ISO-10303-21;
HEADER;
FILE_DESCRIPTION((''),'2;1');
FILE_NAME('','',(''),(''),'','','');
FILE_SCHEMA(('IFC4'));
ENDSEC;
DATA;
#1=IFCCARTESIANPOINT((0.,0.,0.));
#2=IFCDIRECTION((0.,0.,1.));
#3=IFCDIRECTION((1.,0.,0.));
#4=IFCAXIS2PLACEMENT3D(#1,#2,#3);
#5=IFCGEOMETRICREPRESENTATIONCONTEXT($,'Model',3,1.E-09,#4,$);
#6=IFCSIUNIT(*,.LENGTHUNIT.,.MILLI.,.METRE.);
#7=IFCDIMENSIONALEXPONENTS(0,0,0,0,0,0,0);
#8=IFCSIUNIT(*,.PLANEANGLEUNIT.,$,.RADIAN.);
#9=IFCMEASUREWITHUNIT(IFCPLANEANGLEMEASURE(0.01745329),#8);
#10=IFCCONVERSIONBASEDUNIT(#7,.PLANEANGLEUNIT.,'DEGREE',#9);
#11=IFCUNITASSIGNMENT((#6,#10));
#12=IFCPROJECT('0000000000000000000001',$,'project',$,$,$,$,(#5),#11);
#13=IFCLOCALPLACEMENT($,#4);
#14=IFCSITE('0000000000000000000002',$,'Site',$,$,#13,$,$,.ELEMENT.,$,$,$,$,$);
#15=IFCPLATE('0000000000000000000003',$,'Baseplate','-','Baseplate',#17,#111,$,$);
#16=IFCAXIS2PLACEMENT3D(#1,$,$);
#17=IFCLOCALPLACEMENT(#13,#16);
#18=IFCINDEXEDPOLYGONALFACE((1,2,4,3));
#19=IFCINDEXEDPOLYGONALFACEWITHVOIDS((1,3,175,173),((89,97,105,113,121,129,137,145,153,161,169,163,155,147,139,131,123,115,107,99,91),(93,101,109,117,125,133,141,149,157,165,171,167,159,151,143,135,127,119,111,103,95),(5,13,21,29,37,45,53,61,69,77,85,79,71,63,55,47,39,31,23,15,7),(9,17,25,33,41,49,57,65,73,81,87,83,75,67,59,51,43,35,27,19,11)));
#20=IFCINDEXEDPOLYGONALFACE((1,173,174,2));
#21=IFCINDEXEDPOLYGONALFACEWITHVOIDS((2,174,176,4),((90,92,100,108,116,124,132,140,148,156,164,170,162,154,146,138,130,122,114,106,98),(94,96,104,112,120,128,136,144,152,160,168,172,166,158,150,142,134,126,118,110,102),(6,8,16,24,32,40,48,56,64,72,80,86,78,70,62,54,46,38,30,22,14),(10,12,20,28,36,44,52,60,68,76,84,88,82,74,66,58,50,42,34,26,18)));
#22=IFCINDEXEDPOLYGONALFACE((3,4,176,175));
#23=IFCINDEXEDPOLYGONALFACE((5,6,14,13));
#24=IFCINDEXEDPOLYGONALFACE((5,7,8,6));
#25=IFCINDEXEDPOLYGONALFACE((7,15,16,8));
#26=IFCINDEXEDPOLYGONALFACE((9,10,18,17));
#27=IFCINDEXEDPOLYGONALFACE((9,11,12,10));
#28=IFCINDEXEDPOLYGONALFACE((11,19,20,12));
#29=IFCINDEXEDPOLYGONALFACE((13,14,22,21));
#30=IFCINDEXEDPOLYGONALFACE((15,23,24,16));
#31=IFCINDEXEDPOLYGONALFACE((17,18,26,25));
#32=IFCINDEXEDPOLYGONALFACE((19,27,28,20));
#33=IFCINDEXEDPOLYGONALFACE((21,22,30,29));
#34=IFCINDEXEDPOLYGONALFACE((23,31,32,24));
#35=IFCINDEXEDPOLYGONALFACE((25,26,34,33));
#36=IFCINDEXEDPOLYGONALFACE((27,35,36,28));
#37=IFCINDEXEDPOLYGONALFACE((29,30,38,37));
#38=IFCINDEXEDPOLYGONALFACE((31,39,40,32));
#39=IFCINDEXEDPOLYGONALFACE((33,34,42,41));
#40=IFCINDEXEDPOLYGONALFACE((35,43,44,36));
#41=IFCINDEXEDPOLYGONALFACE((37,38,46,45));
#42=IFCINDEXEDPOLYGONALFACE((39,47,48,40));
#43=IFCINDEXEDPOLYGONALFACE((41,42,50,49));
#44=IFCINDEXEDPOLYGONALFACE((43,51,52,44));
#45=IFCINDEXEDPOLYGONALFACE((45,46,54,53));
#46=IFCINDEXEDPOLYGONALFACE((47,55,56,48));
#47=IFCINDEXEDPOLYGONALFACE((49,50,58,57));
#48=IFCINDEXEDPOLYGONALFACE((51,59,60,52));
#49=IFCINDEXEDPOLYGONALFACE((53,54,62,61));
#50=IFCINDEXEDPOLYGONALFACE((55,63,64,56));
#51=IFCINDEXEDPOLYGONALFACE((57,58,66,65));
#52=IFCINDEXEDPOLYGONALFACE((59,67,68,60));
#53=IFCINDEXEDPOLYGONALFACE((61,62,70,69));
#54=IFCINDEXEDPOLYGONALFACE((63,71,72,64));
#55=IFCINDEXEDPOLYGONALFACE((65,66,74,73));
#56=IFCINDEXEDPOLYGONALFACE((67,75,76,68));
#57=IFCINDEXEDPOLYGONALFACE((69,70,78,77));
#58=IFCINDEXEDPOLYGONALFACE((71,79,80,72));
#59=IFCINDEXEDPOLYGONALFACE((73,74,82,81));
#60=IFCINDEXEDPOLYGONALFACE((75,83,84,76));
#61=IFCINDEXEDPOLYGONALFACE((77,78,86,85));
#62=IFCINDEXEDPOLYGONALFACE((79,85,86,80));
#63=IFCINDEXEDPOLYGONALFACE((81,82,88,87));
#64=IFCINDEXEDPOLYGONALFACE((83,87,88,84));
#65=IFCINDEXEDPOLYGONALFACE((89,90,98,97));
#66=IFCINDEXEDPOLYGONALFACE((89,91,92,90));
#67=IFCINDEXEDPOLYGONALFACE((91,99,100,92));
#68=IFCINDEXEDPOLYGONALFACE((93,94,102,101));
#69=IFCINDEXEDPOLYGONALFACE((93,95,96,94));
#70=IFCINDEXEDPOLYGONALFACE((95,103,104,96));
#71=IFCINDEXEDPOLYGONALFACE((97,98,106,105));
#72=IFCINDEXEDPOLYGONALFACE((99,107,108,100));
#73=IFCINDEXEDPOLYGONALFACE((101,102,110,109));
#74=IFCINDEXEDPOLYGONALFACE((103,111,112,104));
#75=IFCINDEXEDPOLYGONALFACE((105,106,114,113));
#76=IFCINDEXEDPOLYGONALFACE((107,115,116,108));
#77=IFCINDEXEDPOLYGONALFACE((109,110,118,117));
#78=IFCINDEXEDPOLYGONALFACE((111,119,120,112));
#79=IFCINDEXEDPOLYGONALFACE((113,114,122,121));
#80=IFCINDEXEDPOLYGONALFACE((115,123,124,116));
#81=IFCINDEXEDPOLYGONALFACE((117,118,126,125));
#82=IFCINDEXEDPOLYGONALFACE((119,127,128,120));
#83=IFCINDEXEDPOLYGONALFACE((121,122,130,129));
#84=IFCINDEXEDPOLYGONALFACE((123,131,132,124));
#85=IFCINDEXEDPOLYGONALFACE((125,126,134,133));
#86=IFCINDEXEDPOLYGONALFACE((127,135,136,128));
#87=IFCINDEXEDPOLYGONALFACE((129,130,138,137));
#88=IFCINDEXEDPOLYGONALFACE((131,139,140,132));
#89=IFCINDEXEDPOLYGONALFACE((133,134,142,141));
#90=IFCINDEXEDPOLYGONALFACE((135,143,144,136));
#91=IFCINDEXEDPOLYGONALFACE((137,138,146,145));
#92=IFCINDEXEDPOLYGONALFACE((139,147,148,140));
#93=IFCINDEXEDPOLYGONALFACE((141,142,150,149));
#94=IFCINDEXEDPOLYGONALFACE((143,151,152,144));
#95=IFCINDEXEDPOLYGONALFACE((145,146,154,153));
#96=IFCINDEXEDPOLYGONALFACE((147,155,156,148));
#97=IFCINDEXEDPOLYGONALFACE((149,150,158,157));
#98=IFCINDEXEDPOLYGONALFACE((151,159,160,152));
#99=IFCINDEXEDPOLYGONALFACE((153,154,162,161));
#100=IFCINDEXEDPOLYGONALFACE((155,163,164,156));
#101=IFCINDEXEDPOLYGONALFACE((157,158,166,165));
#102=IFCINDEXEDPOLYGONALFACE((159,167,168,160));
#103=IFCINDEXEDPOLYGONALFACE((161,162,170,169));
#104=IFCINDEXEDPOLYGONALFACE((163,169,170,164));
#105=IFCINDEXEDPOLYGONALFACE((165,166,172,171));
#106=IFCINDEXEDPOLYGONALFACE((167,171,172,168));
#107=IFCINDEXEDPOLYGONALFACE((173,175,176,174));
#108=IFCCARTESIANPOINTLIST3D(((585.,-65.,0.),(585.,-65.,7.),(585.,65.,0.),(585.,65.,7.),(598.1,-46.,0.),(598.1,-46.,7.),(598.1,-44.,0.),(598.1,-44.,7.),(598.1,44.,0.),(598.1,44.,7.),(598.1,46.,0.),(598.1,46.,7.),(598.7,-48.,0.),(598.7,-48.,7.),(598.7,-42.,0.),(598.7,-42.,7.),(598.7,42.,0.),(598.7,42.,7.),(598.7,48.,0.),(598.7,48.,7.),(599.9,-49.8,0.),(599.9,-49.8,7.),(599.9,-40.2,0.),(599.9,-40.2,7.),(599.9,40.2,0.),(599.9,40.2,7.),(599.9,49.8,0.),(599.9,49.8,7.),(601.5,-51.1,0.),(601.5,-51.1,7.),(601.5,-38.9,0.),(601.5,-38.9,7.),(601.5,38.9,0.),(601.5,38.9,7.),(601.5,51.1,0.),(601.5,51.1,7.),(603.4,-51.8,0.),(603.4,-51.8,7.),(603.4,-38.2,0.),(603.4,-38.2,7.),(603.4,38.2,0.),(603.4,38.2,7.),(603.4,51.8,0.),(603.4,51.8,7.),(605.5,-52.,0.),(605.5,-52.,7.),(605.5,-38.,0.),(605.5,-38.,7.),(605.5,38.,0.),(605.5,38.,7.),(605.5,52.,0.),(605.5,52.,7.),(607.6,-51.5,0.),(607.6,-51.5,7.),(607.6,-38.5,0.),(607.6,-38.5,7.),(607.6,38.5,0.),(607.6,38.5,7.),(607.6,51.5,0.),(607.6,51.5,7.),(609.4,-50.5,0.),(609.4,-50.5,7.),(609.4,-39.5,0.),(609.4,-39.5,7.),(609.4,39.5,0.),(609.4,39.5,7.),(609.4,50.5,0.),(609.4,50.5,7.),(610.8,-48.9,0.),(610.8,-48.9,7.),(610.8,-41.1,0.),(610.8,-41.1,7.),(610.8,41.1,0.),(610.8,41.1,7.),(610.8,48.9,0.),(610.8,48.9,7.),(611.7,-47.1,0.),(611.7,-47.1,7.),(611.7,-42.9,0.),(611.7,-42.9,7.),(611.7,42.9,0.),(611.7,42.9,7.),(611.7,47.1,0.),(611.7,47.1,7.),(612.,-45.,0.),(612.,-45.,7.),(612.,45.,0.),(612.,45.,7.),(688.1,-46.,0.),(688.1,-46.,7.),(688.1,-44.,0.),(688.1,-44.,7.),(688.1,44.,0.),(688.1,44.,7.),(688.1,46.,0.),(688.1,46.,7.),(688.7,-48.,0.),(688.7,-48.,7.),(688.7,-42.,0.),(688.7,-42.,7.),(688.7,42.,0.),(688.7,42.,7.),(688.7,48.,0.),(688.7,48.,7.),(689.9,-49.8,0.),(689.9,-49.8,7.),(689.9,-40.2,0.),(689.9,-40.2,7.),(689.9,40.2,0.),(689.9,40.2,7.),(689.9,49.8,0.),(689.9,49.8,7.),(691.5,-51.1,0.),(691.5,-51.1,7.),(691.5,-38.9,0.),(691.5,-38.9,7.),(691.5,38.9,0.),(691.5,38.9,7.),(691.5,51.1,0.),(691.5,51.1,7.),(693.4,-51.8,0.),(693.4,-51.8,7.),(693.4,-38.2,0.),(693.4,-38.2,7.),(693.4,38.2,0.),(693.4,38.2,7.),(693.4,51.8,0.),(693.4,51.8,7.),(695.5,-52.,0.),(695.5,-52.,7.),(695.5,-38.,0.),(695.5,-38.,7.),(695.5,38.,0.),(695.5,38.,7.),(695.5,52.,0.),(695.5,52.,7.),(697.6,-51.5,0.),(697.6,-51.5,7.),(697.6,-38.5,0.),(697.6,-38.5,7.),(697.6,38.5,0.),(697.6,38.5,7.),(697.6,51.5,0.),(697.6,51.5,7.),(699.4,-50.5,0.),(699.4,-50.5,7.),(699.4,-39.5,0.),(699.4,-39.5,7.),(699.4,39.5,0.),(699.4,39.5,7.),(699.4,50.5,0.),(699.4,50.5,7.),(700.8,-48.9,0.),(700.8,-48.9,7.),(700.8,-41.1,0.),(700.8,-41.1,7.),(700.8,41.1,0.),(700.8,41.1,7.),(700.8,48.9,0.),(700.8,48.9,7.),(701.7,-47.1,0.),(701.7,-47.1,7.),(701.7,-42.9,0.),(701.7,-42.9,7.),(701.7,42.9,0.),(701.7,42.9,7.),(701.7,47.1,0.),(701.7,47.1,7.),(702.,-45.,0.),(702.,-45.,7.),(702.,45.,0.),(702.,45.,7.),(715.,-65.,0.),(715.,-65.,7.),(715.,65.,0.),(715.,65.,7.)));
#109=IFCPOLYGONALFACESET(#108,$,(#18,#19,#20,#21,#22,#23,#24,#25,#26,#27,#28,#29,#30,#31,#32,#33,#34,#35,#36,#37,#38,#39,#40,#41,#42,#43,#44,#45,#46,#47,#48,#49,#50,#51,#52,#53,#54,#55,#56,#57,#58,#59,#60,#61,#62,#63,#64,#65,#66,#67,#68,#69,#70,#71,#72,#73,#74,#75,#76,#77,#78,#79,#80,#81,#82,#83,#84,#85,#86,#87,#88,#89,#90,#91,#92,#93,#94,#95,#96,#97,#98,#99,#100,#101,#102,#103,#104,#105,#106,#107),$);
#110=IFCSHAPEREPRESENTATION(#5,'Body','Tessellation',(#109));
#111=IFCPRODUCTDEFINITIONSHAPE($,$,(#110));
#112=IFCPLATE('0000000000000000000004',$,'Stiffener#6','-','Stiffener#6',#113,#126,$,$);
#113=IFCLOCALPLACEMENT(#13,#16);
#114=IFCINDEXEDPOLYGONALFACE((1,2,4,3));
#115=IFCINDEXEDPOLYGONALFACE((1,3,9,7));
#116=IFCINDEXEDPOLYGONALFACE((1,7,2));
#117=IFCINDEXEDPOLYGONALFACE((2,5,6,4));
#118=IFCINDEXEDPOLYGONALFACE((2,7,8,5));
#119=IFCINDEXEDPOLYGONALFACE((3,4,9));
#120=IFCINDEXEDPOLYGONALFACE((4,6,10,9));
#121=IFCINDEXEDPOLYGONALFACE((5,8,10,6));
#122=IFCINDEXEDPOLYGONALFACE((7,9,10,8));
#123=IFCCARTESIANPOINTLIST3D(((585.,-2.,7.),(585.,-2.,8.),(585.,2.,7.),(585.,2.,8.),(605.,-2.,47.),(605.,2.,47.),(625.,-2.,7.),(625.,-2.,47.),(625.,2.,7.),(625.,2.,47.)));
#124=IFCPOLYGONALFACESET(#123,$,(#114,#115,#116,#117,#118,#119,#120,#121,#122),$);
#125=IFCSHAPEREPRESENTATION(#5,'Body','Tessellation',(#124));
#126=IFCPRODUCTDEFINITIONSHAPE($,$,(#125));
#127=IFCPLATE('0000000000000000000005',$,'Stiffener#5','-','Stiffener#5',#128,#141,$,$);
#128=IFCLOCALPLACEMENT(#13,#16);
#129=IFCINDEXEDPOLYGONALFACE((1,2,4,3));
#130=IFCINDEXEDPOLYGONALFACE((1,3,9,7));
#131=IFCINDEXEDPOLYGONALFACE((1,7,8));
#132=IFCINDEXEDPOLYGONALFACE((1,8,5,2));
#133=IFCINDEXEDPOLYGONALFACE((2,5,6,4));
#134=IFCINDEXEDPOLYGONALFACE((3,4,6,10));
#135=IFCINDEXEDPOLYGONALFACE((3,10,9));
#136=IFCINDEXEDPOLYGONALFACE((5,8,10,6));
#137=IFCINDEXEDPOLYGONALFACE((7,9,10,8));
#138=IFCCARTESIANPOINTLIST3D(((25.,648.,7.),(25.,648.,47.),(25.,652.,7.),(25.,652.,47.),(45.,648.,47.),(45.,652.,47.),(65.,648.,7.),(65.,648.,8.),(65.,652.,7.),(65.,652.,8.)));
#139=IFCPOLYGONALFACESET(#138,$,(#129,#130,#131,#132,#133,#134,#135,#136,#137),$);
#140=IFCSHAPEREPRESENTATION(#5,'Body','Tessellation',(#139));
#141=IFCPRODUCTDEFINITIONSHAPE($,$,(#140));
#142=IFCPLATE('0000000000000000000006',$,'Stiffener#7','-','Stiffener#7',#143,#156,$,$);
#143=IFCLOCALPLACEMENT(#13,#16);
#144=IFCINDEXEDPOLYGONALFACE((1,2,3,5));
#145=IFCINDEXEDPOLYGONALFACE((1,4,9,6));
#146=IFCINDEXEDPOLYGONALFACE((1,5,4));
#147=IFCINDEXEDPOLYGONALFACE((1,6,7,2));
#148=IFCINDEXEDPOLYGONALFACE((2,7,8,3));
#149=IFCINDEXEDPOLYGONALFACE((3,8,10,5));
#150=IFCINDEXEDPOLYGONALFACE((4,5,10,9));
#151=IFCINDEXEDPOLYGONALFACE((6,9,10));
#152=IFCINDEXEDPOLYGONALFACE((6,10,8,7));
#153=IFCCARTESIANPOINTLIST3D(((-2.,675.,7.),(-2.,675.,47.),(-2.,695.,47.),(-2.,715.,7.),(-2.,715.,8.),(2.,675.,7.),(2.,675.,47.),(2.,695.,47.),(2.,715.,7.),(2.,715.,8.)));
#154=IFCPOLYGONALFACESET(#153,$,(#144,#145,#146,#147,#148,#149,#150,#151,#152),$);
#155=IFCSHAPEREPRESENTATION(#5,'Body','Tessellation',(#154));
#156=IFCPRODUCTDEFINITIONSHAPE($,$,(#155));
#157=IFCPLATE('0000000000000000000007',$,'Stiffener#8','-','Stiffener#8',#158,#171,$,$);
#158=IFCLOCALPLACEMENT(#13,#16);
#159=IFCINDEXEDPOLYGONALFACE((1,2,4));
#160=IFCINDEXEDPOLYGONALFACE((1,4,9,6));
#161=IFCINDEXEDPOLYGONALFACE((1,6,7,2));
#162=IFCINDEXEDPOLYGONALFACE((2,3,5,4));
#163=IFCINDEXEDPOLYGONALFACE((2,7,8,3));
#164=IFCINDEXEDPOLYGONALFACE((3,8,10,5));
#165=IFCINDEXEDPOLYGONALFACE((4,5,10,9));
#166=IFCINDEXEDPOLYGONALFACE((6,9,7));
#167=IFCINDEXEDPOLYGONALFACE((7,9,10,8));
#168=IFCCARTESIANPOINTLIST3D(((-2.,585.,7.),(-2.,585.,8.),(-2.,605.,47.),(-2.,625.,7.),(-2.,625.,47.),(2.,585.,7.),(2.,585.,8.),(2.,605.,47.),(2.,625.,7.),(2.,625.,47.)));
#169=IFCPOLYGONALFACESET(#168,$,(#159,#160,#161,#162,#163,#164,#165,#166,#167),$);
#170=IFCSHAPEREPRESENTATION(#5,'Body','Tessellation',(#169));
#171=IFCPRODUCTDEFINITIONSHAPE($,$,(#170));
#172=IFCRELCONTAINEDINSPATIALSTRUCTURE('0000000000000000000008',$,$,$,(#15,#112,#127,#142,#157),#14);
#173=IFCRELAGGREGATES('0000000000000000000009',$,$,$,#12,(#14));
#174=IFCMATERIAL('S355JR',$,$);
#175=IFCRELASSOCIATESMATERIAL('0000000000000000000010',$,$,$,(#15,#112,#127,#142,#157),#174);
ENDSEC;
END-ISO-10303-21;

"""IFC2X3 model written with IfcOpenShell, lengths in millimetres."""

from ifc_helpers import new_model, entity, si_unit, converted_unit, frame, frame_2d, origin, origin_with_axes, place, context, project, spatial, polyline, circle, outline, extrude, material, element, save


model = new_model("IFC2X3")

# Units and contexts
model_context = context("Model", 3, precision=1e-09, world=origin_with_axes())
ifc_project = project(units=[si_unit("LENGTHUNIT", "METRE", prefix="MILLI"), converted_unit("PLANEANGLEUNIT", "DEGREE", entity("IfcPlaneAngleMeasure", 0.01745329), si_unit("PLANEANGLEUNIT", "RADIAN"), dimensions=[0, 0, 0, 0, 0, 0, 0])], contexts=[model_context])

# Site
site_placement = place(None, origin_with_axes())
site = spatial("IfcSite", under=ifc_project, at=site_placement, Name="Site", CompositionType="ELEMENT")

# Shared definitions
ifc_material = material(Name="S355JR")

# Plate, openings
plate_1_placement = place(None, frame((585.0, 65.0, 7.0), z_axis=(0.0, 0.0, -1.0), x_axis=(1.0, 0.0, 0.0)))
plate_1 = element("IfcPlate", 1, at=plate_1_placement, inside=site, material=ifc_material, Name="Baseplate", Description="-", ObjectType="Baseplate", context=model_context, shape_type="SweptSolid", body=[
    extrude(outline(polyline([(0.0, 0.0), (130.0, 0.0), (130.0, 130.0), (0.0, 130.0), (0.0, 0.0)])), origin_with_axes(), (0.0, 0.0, 1.0), 7.0),
])
opening_1_placement = place(plate_1_placement, frame((20.0, 65.0, 7.5), z_axis=(0.0, 0.0, -1.0), x_axis=(1.0, 0.0, 0.0)))
element("IfcOpeningElement", 2, at=opening_1_placement, cuts=plate_1, ObjectType="Opening", context=model_context, shape_type="SweptSolid", body=[
    extrude(circle(Radius=7.0, at=frame_2d((0.0, 45.0), x_axis=(1.0, 0.0))), origin(), (0.0, 0.0, 1.0), 8.0),
])
opening_2_placement = place(plate_1_placement, frame((20.0, 65.0, 7.5), z_axis=(0.0, 0.0, -1.0), x_axis=(1.0, 0.0, 0.0)))
element("IfcOpeningElement", 3, at=opening_2_placement, cuts=plate_1, ObjectType="Opening", context=model_context, shape_type="SweptSolid", body=[
    extrude(circle(Radius=7.0, at=frame_2d((0.0, -45.0), x_axis=(1.0, 0.0))), origin(), (0.0, 0.0, 1.0), 8.0),
])
opening_3_placement = place(plate_1_placement, frame((110.0, 65.0, 7.5), z_axis=(0.0, 0.0, -1.0), x_axis=(1.0, 0.0, 0.0)))
element("IfcOpeningElement", 4, at=opening_3_placement, cuts=plate_1, ObjectType="Opening", context=model_context, shape_type="SweptSolid", body=[
    extrude(circle(Radius=7.0, at=frame_2d((0.0, 45.0), x_axis=(1.0, 0.0))), origin(), (0.0, 0.0, 1.0), 8.0),
])
opening_4_placement = place(plate_1_placement, frame((110.0, 65.0, 7.5), z_axis=(0.0, 0.0, -1.0), x_axis=(1.0, 0.0, 0.0)))
element("IfcOpeningElement", 5, at=opening_4_placement, cuts=plate_1, ObjectType="Opening", context=model_context, shape_type="SweptSolid", body=[
    extrude(circle(Radius=7.0, at=frame_2d((0.0, -45.0), x_axis=(1.0, 0.0))), origin(), (0.0, 0.0, 1.0), 8.0),
])

# Plates, openings
plate_2_placement = place(None, frame((625.0, -2.0, 7.0), z_axis=(0.0, 1.0, 0.0), x_axis=(-1.0, 0.0, 0.0)))
plate_2 = element("IfcPlate", 6, at=plate_2_placement, inside=site, material=ifc_material, Name="Stiffener#6", Description="-", ObjectType="Stiffener#6", context=model_context, shape_type="SweptSolid", body=[
    extrude(outline(polyline([(0.0, 0.0), (40.0, 0.0), (40.0, 40.0), (0.0, 40.0), (0.0, 0.0)])), origin_with_axes(), (0.0, 0.0, 1.0), 4.0),
])
opening_5_placement = place(plate_2_placement, frame((0.0, 0.0, 0.0), z_axis=(0.0, 0.0, 1.0), x_axis=(1.0, 0.0, 0.0)))
element("IfcOpeningElement", 7, at=opening_5_placement, cuts=plate_2, ObjectType="Opening", context=model_context, shape_type="SweptSolid", body=[
    extrude(outline(polyline([(40.0, 40.0), (20.0, 40.0), (40.0, 1.0), (40.0, 40.0)])), origin(), (0.0, 0.0, 1.0), 4.0),
])
plate_3_placement = place(None, frame((25.0, 648.0, 7.0), z_axis=(0.0, 1.0, 0.0), x_axis=(0.0, 0.0, 1.0)))
plate_3 = element("IfcPlate", 8, at=plate_3_placement, inside=site, material=ifc_material, Name="Stiffener#5", Description="-", ObjectType="Stiffener#5", context=model_context, shape_type="SweptSolid", body=[
    extrude(outline(polyline([(0.0, 0.0), (40.0, 0.0), (40.0, 40.0), (0.0, 40.0), (0.0, 0.0)])), origin_with_axes(), (0.0, 0.0, 1.0), 4.0),
])
opening_6_placement = place(plate_3_placement, frame((0.0, 0.0, 0.0), z_axis=(0.0, 0.0, 1.0), x_axis=(1.0, 0.0, 0.0)))
element("IfcOpeningElement", 9, at=opening_6_placement, cuts=plate_3, ObjectType="Opening", context=model_context, shape_type="SweptSolid", body=[
    extrude(outline(polyline([(40.0, 40.0), (1.0, 40.0), (40.0, 20.0), (40.0, 40.0)])), origin(), (0.0, 0.0, 1.0), 4.0),
])
plate_4_placement = place(None, frame((2.0, 675.0, 7.0), z_axis=(-1.0, 0.0, 0.0), x_axis=(0.0, 0.0, 1.0)))
plate_4 = element("IfcPlate", 10, at=plate_4_placement, inside=site, material=ifc_material, Name="Stiffener#7", Description="-", ObjectType="Stiffener#7", context=model_context, shape_type="SweptSolid", body=[
    extrude(outline(polyline([(0.0, 0.0), (40.0, 0.0), (40.0, 40.0), (0.0, 40.0), (0.0, 0.0)])), origin_with_axes(), (0.0, 0.0, 1.0), 4.0),
])
opening_7_placement = place(plate_4_placement, frame((0.0, 0.0, 0.0), z_axis=(0.0, 0.0, 1.0), x_axis=(1.0, 0.0, 0.0)))
element("IfcOpeningElement", 11, at=opening_7_placement, cuts=plate_4, ObjectType="Opening", context=model_context, shape_type="SweptSolid", body=[
    extrude(outline(polyline([(40.0, 40.0), (1.0, 40.0), (40.0, 20.0), (40.0, 40.0)])), origin(), (0.0, 0.0, 1.0), 4.0),
])
plate_5_placement = place(None, frame((2.0, 625.0, 7.0), z_axis=(-1.0, 0.0, 0.0), x_axis=(0.0, -1.0, 0.0)))
plate_5 = element("IfcPlate", 12, at=plate_5_placement, inside=site, material=ifc_material, Name="Stiffener#8", Description="-", ObjectType="Stiffener#8", context=model_context, shape_type="SweptSolid", body=[
    extrude(outline(polyline([(0.0, 0.0), (40.0, 0.0), (40.0, 40.0), (0.0, 40.0), (0.0, 0.0)])), origin_with_axes(), (0.0, 0.0, 1.0), 4.0),
])
opening_8_placement = place(plate_5_placement, frame((0.0, 0.0, 0.0), z_axis=(0.0, 0.0, 1.0), x_axis=(1.0, 0.0, 0.0)))
element("IfcOpeningElement", 13, at=opening_8_placement, cuts=plate_5, ObjectType="Opening", context=model_context, shape_type="SweptSolid", body=[
    extrude(outline(polyline([(40.0, 40.0), (20.0, 40.0), (40.0, 1.0), (40.0, 40.0)])), origin(), (0.0, 0.0, 1.0), 4.0),
])

save(model, "model.ifc")
